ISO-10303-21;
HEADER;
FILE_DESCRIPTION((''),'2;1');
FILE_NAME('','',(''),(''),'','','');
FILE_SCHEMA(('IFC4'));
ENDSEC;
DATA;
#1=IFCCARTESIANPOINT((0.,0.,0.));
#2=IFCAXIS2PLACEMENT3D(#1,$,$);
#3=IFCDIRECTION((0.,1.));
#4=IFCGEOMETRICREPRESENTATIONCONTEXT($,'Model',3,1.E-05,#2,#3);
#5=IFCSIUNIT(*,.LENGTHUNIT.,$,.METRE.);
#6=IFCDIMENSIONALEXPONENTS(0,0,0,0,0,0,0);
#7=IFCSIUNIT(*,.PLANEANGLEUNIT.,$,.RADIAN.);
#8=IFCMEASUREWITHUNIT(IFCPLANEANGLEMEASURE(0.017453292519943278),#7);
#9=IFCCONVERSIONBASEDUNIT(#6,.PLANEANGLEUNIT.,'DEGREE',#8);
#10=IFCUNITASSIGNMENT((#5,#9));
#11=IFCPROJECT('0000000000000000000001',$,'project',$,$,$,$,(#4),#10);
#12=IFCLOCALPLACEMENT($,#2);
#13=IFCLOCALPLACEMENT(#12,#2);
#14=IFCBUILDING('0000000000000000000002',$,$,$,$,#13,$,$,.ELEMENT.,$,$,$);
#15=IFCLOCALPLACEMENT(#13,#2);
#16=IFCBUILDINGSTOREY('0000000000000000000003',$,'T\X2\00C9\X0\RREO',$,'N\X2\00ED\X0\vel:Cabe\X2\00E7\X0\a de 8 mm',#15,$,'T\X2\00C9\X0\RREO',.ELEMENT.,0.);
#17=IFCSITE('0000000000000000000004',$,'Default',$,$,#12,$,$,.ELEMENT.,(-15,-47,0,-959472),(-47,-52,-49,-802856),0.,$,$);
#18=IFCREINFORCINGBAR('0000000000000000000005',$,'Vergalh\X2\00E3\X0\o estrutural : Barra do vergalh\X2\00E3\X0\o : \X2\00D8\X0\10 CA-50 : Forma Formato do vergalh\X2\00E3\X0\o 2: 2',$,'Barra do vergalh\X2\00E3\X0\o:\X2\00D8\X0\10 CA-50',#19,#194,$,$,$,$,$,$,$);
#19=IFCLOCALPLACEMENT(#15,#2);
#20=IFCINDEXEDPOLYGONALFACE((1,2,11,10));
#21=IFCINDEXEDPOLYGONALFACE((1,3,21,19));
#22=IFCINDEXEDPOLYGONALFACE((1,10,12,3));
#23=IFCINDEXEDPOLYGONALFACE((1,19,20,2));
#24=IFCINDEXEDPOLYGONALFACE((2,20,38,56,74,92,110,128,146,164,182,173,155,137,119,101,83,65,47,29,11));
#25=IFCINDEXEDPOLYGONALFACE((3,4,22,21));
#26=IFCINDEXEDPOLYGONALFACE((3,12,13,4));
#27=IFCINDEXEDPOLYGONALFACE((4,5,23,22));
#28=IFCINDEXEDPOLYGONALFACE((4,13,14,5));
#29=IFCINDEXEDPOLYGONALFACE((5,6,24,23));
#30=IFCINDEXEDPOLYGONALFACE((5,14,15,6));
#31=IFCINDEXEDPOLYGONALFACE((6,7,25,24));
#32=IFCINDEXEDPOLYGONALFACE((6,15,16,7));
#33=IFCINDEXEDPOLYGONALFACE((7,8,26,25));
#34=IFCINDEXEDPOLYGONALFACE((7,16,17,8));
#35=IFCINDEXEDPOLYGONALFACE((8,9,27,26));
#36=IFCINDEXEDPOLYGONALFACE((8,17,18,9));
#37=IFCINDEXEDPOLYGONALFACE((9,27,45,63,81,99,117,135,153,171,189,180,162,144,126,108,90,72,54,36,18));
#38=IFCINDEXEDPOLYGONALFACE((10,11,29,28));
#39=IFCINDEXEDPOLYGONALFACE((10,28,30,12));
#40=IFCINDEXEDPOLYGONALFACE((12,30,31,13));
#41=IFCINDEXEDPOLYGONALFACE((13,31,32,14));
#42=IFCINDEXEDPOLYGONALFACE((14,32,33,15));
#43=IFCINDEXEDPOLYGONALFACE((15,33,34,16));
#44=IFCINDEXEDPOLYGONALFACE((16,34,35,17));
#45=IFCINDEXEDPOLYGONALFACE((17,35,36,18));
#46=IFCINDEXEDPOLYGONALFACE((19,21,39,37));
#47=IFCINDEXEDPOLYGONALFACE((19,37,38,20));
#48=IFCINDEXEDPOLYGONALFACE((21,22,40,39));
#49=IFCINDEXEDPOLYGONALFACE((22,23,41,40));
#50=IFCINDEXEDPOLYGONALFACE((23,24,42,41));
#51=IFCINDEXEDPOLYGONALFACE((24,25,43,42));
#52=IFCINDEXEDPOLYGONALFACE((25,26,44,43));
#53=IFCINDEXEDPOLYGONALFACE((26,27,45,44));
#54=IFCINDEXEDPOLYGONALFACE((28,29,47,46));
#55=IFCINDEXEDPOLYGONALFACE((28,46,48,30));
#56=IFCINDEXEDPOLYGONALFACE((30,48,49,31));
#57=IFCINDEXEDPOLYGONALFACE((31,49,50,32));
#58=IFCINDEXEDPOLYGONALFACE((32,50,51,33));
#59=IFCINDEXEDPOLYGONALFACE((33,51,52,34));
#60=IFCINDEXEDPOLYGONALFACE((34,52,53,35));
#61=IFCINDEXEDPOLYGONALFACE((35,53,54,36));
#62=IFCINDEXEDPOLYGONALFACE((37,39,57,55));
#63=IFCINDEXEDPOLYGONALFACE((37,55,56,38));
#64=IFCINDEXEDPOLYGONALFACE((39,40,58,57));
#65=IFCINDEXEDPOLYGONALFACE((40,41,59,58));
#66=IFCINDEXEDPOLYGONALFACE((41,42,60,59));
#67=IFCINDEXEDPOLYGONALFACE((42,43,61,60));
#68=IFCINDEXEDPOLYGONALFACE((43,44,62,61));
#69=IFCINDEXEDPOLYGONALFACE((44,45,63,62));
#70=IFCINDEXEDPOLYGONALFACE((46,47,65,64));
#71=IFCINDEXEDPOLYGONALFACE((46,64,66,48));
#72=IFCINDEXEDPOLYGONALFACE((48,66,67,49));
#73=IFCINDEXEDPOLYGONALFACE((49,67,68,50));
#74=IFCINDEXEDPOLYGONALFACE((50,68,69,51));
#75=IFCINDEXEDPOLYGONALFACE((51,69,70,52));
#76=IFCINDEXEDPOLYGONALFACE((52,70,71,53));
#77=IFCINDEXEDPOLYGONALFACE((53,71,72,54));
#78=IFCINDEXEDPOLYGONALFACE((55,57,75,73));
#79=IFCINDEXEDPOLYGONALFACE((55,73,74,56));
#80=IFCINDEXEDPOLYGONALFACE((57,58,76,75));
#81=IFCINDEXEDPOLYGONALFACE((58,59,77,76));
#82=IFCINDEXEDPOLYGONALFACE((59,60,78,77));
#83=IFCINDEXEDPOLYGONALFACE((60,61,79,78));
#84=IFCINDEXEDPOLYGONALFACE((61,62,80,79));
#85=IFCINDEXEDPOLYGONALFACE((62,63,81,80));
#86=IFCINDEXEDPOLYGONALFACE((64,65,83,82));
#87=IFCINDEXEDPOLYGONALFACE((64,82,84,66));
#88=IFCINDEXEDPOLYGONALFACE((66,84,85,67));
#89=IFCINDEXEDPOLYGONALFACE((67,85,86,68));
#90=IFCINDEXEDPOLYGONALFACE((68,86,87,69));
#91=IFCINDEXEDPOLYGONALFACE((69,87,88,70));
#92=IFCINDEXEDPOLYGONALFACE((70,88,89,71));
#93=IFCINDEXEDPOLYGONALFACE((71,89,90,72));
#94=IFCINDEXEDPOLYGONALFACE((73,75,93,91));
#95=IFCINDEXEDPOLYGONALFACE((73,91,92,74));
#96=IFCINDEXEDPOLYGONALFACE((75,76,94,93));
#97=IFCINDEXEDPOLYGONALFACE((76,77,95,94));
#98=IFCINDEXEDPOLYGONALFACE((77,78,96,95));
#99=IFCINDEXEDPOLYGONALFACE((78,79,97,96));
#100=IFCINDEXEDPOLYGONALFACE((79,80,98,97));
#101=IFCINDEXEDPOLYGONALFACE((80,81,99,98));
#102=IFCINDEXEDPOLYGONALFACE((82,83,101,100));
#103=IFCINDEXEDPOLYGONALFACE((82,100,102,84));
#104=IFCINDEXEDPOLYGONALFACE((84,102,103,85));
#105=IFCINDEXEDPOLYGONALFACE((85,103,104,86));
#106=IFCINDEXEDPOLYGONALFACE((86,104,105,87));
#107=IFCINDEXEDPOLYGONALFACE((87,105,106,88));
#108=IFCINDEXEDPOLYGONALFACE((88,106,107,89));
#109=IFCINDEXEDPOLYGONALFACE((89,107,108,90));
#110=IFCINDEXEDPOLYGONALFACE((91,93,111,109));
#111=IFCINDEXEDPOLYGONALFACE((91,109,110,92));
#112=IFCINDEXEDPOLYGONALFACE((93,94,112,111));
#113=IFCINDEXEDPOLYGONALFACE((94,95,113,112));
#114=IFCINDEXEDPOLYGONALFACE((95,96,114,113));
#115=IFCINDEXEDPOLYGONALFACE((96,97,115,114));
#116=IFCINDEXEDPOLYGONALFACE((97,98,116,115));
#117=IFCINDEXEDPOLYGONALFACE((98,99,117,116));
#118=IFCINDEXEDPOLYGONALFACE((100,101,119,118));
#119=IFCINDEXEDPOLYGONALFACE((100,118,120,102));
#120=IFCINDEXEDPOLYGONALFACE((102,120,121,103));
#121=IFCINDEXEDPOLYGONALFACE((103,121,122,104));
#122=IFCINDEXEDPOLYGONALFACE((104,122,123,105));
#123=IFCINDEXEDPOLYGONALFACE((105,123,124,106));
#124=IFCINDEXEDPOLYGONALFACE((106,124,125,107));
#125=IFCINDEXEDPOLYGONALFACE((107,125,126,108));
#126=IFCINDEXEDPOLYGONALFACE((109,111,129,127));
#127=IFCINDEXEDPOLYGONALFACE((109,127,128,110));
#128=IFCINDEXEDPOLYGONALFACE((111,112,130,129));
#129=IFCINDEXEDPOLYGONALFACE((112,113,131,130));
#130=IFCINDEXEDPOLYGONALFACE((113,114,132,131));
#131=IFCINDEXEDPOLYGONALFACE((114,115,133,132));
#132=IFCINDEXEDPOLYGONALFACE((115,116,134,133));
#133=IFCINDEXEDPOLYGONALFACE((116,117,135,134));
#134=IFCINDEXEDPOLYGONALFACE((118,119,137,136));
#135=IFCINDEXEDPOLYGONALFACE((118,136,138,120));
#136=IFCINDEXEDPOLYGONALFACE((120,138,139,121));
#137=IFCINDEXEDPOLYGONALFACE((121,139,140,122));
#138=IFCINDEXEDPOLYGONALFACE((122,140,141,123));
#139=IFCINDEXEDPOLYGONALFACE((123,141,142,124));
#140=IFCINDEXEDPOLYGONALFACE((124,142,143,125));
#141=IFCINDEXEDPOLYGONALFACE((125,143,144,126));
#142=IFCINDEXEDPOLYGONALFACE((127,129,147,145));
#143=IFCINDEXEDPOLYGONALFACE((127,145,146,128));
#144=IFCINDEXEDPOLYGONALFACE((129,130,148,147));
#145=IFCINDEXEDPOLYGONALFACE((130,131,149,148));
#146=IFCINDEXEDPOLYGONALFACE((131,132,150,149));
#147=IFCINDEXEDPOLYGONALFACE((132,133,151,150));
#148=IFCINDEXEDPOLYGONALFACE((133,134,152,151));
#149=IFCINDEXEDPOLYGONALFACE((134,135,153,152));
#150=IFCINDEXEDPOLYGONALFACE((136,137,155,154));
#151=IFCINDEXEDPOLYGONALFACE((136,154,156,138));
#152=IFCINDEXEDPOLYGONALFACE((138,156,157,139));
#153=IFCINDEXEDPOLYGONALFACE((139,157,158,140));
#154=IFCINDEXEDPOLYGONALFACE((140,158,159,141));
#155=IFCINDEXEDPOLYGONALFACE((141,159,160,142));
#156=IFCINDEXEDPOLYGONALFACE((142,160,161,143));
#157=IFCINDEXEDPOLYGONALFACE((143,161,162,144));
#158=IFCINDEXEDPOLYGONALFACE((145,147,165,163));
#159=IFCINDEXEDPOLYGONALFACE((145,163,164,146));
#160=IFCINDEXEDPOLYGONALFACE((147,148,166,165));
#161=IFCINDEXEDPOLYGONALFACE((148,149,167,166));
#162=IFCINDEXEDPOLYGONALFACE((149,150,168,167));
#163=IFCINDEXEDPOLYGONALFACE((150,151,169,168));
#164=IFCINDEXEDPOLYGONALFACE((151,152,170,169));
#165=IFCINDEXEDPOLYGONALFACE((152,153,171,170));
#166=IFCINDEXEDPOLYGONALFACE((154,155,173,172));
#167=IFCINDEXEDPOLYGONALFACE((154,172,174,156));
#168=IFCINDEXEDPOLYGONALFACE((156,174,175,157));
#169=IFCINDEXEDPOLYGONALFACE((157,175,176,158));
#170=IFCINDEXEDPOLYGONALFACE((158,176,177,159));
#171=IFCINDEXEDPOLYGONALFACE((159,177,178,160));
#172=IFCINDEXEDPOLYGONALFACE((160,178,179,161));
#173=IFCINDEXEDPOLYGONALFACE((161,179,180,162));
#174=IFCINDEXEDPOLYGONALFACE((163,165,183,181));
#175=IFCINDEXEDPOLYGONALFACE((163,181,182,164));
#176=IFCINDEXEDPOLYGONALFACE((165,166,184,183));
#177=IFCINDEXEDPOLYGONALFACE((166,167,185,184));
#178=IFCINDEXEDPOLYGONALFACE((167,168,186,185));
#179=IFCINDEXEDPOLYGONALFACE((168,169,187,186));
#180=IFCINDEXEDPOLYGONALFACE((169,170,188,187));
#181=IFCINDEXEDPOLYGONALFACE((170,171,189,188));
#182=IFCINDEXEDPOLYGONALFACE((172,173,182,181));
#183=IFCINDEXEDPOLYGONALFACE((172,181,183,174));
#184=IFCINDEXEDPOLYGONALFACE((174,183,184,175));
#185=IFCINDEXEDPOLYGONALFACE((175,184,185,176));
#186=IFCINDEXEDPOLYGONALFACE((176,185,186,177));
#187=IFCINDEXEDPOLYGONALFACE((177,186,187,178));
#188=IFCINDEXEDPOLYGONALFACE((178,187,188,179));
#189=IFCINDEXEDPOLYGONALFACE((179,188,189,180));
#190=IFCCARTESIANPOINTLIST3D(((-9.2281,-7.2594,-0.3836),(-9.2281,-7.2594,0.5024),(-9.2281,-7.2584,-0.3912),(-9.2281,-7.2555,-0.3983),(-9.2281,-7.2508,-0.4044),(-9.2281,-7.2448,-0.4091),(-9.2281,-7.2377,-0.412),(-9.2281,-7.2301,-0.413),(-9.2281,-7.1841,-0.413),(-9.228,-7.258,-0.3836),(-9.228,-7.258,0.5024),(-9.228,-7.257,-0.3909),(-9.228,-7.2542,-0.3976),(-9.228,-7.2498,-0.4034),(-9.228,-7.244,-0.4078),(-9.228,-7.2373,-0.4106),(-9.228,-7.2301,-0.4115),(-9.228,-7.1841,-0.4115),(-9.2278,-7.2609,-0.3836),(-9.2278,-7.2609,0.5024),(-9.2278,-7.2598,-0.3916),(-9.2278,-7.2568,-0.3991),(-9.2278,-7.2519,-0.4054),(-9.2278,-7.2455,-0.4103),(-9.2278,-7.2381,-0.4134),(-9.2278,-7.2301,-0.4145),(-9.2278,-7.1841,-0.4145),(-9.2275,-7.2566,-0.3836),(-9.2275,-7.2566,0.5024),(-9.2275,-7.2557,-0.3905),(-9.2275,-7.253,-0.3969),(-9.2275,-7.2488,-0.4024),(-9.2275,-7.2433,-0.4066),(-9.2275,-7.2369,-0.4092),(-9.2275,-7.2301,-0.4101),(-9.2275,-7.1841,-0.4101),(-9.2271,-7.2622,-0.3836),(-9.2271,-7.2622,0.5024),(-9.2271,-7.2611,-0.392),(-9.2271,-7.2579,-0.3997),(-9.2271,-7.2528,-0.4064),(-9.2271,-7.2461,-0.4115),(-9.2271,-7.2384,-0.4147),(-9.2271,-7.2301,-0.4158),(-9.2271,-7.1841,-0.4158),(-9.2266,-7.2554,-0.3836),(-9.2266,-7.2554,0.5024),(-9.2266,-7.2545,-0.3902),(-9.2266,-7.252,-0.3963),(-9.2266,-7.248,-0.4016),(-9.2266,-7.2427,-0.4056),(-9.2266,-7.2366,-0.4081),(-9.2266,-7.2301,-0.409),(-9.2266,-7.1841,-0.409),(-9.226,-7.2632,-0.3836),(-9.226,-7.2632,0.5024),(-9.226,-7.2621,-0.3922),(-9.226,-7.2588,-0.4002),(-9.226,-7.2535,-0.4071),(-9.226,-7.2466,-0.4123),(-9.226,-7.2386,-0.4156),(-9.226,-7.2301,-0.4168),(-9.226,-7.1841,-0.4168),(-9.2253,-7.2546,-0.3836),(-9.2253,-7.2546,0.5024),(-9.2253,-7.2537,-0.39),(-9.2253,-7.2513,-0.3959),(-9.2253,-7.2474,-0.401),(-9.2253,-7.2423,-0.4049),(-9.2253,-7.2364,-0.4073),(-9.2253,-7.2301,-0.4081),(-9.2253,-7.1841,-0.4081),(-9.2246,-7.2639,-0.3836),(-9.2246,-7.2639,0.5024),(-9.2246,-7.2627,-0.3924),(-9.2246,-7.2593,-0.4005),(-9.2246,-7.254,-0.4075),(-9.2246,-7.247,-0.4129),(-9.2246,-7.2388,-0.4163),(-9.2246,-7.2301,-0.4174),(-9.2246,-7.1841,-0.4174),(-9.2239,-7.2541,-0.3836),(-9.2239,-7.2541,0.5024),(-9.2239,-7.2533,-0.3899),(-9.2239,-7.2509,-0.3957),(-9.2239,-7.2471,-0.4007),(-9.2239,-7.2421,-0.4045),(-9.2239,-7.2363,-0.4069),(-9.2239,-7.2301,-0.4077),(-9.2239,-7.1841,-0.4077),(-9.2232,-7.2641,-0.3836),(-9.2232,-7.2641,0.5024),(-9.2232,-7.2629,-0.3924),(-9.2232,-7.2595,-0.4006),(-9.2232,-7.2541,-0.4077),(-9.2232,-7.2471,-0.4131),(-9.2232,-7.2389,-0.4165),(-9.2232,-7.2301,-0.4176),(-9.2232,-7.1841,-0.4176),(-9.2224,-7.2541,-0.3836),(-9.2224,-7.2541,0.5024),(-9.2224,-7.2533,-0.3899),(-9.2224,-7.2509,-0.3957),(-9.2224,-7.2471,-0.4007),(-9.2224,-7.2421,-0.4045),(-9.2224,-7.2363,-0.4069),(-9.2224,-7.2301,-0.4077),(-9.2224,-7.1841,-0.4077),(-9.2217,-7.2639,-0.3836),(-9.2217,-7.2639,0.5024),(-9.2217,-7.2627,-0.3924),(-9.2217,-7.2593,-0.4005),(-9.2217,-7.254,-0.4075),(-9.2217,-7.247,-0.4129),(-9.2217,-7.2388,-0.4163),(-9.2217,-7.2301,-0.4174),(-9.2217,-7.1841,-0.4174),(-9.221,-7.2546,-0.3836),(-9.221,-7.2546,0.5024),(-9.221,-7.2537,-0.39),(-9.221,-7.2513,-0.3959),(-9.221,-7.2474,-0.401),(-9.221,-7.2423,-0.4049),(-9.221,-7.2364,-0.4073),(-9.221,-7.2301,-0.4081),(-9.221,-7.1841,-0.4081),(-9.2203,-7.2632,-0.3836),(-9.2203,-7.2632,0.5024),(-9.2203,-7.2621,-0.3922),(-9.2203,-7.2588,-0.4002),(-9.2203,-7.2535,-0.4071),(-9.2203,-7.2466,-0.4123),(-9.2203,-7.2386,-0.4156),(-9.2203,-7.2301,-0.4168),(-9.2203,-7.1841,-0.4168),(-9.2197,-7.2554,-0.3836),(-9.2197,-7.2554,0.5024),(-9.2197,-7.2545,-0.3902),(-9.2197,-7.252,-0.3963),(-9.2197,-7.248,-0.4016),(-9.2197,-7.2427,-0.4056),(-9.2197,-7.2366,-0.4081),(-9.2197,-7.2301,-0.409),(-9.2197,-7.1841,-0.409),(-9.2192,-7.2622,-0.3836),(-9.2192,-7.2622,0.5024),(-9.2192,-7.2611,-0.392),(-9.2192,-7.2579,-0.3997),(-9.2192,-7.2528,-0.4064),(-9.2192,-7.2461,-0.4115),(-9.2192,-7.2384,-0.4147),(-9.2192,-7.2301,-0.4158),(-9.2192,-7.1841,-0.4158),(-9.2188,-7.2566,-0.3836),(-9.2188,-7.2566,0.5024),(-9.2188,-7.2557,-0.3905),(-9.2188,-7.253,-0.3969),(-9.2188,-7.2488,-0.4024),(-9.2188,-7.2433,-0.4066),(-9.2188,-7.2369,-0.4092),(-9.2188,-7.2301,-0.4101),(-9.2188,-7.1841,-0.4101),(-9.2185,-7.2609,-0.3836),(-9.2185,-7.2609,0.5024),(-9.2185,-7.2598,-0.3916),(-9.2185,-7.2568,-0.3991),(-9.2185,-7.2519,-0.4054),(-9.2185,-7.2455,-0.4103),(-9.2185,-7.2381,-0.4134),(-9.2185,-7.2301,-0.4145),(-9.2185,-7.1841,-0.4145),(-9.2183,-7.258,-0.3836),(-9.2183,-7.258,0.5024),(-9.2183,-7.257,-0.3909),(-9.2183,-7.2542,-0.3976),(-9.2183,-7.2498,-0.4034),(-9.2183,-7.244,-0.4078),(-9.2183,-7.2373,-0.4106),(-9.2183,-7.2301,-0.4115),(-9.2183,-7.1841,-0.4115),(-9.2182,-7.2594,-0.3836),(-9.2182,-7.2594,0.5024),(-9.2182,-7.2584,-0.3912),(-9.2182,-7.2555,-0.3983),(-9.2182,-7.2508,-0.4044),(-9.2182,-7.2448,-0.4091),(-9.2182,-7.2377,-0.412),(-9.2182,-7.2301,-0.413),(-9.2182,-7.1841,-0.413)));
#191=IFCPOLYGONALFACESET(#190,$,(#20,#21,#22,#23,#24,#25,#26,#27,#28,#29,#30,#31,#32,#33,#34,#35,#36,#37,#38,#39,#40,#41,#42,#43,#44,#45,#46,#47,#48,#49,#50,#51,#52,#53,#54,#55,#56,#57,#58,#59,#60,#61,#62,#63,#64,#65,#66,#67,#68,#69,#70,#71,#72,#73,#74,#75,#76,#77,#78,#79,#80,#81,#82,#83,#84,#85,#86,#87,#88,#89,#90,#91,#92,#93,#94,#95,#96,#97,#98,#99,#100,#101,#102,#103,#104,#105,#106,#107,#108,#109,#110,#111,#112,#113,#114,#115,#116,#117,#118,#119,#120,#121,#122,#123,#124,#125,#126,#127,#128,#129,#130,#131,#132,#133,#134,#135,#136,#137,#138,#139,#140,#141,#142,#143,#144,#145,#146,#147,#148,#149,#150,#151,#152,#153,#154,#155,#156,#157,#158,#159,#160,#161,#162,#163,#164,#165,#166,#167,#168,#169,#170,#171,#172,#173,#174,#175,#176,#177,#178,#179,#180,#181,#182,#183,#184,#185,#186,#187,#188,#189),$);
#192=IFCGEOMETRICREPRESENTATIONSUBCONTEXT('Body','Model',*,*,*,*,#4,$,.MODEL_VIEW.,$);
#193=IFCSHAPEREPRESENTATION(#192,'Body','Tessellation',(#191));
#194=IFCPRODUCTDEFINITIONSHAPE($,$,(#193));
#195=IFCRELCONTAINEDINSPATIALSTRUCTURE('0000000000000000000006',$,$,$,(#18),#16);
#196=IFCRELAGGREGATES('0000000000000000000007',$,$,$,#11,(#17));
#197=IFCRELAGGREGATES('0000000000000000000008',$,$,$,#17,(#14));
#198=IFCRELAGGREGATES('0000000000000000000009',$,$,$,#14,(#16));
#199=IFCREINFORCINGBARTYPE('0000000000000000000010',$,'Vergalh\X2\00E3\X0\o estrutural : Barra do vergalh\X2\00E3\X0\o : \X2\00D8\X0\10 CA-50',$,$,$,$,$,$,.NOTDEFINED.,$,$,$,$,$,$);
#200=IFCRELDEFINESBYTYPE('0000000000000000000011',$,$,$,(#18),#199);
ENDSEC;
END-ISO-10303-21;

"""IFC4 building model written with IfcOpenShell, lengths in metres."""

from ifc_helpers import new_model, entity, si_unit, converted_unit, direction, origin, place, context, subcontext, project, spatial, type_object, element, save


model = new_model("IFC4")

# Units and contexts
model_context = context("Model", 3, precision=1e-05, world=origin(), true_north=direction((0.0, 1.0)))
body_context = subcontext(model_context, "Body", "Model", "MODEL_VIEW")
ifc_project = project(units=[si_unit("LENGTHUNIT", "METRE"), converted_unit("PLANEANGLEUNIT", "DEGREE", entity("IfcPlaneAngleMeasure", 0.017453292519943278), si_unit("PLANEANGLEUNIT", "RADIAN"), dimensions=[0, 0, 0, 0, 0, 0, 0])], contexts=[model_context])

# Site, building, storey
site_placement = place(None, origin())
site = spatial("IfcSite", under=ifc_project, at=site_placement, Name="Default", CompositionType="ELEMENT", RefLatitude=(-15, -47, 0, -959472), RefLongitude=(-47, -52, -49, -802856), RefElevation=0.0)
building_placement = place(site_placement, origin())
building = spatial("IfcBuilding", under=site, at=building_placement, CompositionType="ELEMENT")
storey_placement = place(building_placement, origin())
storey = spatial("IfcBuildingStorey", under=building, at=storey_placement, Name="TÉRREO", ObjectType="Nível:Cabeça de 8 mm", LongName="TÉRREO", CompositionType="ELEMENT", Elevation=0.0)

# Reinforcing bar
reinforcing_bar_type_1 = type_object("IfcReinforcingBarType", Name="Vergalhão estrutural : Barra do vergalhão : Ø10 CA-50", PredefinedType="NOTDEFINED")
reinforcing_bar_1_placement = place(storey_placement, origin())
element("IfcReinforcingBar", 1, at=reinforcing_bar_1_placement, inside=storey, type_object=reinforcing_bar_type_1, Name="Vergalhão estrutural : Barra do vergalhão : Ø10 CA-50 : Forma Formato do vergalhão 2: 2", ObjectType="Barra do vergalhão:Ø10 CA-50", context=body_context, shape_type="AdvancedSweptSolid", body=[
    entity("IfcSweptDiskSolid", entity("IfcIndexedPolyCurve", entity("IfcCartesianPointList3D", [[-9.2232, -7.1841, -0.4126], [-9.2232, -7.2301, -0.4126], [-9.2232, -7.2506, -0.4042], [-9.2232, -7.2591, -0.3836], [-9.2232, -7.2591, 0.5024]]), [entity("IfcLineIndex", [1, 2]), entity("IfcArcIndex", [2, 3, 4]), entity("IfcLineIndex", [4, 5])], False), 0.005, None, 0.0, 92.0),
])

save(model, "model.ifc")
